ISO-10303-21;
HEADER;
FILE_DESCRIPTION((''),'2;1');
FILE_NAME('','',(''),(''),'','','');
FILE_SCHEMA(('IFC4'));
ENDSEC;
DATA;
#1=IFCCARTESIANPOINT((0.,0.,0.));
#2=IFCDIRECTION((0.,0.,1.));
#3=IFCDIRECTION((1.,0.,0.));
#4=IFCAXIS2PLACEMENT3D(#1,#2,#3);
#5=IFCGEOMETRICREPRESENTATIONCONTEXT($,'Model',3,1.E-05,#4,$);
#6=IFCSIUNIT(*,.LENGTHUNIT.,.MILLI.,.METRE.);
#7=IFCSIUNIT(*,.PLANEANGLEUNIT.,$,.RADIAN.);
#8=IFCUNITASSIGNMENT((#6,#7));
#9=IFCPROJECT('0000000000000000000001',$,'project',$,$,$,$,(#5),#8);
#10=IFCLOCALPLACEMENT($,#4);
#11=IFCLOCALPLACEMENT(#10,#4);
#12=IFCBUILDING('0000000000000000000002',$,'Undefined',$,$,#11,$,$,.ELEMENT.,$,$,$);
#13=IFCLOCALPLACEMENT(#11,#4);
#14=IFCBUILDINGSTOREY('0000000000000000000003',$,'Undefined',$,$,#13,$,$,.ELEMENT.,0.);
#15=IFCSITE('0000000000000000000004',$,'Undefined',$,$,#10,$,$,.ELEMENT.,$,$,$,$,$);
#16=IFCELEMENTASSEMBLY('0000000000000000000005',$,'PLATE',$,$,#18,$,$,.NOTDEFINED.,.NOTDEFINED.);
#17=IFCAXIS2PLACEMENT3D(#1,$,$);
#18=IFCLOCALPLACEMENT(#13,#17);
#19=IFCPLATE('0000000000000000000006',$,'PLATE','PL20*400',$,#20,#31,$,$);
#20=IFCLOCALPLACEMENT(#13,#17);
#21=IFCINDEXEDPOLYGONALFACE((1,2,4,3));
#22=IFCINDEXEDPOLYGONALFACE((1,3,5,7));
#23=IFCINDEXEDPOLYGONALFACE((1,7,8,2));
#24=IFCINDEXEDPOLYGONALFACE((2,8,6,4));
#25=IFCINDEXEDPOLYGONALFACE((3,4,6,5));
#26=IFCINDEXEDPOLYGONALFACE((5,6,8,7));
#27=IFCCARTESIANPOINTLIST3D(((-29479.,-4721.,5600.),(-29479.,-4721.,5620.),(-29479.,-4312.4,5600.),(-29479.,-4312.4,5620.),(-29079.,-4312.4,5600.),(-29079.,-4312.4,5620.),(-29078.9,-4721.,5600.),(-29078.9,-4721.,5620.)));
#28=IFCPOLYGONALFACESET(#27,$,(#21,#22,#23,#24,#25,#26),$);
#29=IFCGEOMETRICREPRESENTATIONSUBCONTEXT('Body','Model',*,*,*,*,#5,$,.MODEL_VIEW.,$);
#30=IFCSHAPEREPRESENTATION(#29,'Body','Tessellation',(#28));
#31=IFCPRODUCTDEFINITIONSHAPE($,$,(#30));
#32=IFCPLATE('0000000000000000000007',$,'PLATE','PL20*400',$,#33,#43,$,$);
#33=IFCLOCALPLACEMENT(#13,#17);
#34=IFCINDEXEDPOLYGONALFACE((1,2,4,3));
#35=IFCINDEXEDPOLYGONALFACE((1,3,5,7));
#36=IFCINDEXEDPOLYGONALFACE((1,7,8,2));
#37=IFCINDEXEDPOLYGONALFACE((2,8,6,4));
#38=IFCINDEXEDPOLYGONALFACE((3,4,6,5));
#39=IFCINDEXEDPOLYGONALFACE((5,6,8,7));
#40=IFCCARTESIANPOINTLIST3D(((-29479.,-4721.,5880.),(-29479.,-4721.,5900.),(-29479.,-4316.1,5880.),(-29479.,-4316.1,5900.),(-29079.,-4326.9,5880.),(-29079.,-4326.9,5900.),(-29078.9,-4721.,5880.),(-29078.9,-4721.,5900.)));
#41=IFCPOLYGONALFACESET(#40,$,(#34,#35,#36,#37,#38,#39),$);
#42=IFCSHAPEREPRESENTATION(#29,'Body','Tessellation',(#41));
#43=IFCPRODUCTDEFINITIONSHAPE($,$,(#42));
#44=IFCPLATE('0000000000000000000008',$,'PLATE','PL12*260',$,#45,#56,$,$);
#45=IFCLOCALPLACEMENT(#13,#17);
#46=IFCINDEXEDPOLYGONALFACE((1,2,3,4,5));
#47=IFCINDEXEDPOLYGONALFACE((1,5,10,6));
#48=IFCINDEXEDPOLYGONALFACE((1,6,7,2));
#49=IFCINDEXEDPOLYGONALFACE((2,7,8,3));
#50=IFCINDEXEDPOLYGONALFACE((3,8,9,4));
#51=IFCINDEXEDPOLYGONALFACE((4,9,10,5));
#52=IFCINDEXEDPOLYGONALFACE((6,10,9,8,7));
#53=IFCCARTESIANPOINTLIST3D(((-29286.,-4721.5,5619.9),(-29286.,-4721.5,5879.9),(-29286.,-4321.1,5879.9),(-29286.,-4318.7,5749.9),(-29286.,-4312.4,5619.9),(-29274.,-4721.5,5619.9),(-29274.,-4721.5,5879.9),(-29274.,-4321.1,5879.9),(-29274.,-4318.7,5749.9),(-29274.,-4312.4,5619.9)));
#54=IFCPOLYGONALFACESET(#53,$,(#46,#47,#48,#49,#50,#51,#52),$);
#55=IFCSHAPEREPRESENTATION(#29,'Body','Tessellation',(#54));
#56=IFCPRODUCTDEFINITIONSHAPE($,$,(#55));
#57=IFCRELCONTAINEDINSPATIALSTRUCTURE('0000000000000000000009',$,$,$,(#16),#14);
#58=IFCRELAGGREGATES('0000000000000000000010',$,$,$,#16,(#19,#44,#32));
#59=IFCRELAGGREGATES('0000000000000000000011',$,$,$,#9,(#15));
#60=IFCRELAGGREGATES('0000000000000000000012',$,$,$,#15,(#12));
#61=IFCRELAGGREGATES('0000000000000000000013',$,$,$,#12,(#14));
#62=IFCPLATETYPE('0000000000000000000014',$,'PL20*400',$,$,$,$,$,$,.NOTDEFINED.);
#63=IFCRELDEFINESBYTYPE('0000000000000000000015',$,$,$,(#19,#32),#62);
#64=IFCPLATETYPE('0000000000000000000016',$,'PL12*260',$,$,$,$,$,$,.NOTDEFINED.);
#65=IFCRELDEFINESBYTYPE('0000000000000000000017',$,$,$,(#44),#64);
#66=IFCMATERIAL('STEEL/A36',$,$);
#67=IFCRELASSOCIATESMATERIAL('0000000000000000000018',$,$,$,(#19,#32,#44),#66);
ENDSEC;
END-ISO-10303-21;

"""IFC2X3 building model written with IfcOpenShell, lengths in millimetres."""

from ifc_helpers import new_model, si_unit, frame, origin_with_axes, place, context, subcontext, project, spatial, polyline, outline, extrude, material, type_object, element, aggregate, save


model = new_model("IFC2X3")

# Units and contexts
model_context = context("Model", 3, precision=1e-05, world=origin_with_axes())
body_context = subcontext(model_context, "Body", "Model", "MODEL_VIEW")
ifc_project = project(units=[si_unit("LENGTHUNIT", "METRE", prefix="MILLI"), si_unit("PLANEANGLEUNIT", "RADIAN")], contexts=[model_context])

# Site, building, storey
site_placement = place(None, origin_with_axes())
site = spatial("IfcSite", under=ifc_project, at=site_placement, Name="Undefined", CompositionType="ELEMENT")
building_placement = place(site_placement, origin_with_axes())
building = spatial("IfcBuilding", under=site, at=building_placement, Name="Undefined", CompositionType="ELEMENT")
storey_placement = place(building_placement, origin_with_axes())
storey = spatial("IfcBuildingStorey", under=building, at=storey_placement, Name="Undefined", CompositionType="ELEMENT", Elevation=0.0)

# Element assembly
assembly_1_placement = place(storey_placement, origin_with_axes())
assembly_1 = element("IfcElementAssembly", 1, at=assembly_1_placement, inside=storey, Name="PLATE", AssemblyPlace="NOTDEFINED", PredefinedType="NOTDEFINED")
ifc_material_1 = material(Name="STEEL/A36")

# Plates
plate_type_1 = type_object("IfcPlateType", Name="PL20*400", PredefinedType="NOTDEFINED")
plate_1_placement = place(assembly_1_placement, frame((-29078.9, -4721.0, 5610.0), z_axis=(0.0, 0.0, -1.0), x_axis=(-1.0, 0.0, 0.0)))
plate_1 = element("IfcPlate", 2, at=plate_1_placement, type_object=plate_type_1, material=ifc_material_1, Name="PLATE", Description="PL20*400", context=body_context, shape_type="SweptSolid", body=[
    extrude(outline(polyline([(0.0, 0.0), (400.1, 0.0), (400.1, 408.6), (0.1, 408.6), (0.0, 0.0)])), frame((0.0, 0.0, -10.0), z_axis=(0.0, 0.0, 1.0), x_axis=(1.0, 0.0, 0.0)), (0.0, 0.0, 1.0), 20.0),
])
plate_2_placement = place(assembly_1_placement, frame((-29078.9, -4721.0, 5890.0), z_axis=(0.0, 0.0, -1.0), x_axis=(-1.0, 0.0, 0.0)))
plate_2 = element("IfcPlate", 3, at=plate_2_placement, type_object=plate_type_1, material=ifc_material_1, Name="PLATE", Description="PL20*400", context=body_context, shape_type="SweptSolid", body=[
    extrude(outline(polyline([(0.0, 0.0), (400.1, 0.0), (400.1, 404.9), (0.1, 394.1), (0.0, 0.0)])), frame((0.0, 0.0, -10.0), z_axis=(0.0, 0.0, 1.0), x_axis=(1.0, 0.0, 0.0)), (0.0, 0.0, 1.0), 20.0),
])
plate_type_2 = type_object("IfcPlateType", Name="PL12*260", PredefinedType="NOTDEFINED")
plate_3_placement = place(assembly_1_placement, frame((-29280.0, -4721.5, 5879.9), z_axis=(1.0, 0.0, 0.0), x_axis=(0.0, 0.0, -1.0)))
plate_3 = element("IfcPlate", 4, at=plate_3_placement, type_object=plate_type_2, material=ifc_material_1, Name="PLATE", Description="PL12*260", context=body_context, shape_type="SweptSolid", body=[
    extrude(outline(polyline([(0.0, 0.0), (260.0, 0.0), (260.0, 409.1), (130.0, 402.7), (0.0, 400.3), (0.0, 0.0)])), frame((0.0, 0.0, -6.0), z_axis=(0.0, 0.0, 1.0), x_axis=(1.0, 0.0, 0.0)), (0.0, 0.0, 1.0), 12.0),
])
aggregate(assembly_1, [plate_1, plate_3, plate_2])

save(model, "model.ifc")
